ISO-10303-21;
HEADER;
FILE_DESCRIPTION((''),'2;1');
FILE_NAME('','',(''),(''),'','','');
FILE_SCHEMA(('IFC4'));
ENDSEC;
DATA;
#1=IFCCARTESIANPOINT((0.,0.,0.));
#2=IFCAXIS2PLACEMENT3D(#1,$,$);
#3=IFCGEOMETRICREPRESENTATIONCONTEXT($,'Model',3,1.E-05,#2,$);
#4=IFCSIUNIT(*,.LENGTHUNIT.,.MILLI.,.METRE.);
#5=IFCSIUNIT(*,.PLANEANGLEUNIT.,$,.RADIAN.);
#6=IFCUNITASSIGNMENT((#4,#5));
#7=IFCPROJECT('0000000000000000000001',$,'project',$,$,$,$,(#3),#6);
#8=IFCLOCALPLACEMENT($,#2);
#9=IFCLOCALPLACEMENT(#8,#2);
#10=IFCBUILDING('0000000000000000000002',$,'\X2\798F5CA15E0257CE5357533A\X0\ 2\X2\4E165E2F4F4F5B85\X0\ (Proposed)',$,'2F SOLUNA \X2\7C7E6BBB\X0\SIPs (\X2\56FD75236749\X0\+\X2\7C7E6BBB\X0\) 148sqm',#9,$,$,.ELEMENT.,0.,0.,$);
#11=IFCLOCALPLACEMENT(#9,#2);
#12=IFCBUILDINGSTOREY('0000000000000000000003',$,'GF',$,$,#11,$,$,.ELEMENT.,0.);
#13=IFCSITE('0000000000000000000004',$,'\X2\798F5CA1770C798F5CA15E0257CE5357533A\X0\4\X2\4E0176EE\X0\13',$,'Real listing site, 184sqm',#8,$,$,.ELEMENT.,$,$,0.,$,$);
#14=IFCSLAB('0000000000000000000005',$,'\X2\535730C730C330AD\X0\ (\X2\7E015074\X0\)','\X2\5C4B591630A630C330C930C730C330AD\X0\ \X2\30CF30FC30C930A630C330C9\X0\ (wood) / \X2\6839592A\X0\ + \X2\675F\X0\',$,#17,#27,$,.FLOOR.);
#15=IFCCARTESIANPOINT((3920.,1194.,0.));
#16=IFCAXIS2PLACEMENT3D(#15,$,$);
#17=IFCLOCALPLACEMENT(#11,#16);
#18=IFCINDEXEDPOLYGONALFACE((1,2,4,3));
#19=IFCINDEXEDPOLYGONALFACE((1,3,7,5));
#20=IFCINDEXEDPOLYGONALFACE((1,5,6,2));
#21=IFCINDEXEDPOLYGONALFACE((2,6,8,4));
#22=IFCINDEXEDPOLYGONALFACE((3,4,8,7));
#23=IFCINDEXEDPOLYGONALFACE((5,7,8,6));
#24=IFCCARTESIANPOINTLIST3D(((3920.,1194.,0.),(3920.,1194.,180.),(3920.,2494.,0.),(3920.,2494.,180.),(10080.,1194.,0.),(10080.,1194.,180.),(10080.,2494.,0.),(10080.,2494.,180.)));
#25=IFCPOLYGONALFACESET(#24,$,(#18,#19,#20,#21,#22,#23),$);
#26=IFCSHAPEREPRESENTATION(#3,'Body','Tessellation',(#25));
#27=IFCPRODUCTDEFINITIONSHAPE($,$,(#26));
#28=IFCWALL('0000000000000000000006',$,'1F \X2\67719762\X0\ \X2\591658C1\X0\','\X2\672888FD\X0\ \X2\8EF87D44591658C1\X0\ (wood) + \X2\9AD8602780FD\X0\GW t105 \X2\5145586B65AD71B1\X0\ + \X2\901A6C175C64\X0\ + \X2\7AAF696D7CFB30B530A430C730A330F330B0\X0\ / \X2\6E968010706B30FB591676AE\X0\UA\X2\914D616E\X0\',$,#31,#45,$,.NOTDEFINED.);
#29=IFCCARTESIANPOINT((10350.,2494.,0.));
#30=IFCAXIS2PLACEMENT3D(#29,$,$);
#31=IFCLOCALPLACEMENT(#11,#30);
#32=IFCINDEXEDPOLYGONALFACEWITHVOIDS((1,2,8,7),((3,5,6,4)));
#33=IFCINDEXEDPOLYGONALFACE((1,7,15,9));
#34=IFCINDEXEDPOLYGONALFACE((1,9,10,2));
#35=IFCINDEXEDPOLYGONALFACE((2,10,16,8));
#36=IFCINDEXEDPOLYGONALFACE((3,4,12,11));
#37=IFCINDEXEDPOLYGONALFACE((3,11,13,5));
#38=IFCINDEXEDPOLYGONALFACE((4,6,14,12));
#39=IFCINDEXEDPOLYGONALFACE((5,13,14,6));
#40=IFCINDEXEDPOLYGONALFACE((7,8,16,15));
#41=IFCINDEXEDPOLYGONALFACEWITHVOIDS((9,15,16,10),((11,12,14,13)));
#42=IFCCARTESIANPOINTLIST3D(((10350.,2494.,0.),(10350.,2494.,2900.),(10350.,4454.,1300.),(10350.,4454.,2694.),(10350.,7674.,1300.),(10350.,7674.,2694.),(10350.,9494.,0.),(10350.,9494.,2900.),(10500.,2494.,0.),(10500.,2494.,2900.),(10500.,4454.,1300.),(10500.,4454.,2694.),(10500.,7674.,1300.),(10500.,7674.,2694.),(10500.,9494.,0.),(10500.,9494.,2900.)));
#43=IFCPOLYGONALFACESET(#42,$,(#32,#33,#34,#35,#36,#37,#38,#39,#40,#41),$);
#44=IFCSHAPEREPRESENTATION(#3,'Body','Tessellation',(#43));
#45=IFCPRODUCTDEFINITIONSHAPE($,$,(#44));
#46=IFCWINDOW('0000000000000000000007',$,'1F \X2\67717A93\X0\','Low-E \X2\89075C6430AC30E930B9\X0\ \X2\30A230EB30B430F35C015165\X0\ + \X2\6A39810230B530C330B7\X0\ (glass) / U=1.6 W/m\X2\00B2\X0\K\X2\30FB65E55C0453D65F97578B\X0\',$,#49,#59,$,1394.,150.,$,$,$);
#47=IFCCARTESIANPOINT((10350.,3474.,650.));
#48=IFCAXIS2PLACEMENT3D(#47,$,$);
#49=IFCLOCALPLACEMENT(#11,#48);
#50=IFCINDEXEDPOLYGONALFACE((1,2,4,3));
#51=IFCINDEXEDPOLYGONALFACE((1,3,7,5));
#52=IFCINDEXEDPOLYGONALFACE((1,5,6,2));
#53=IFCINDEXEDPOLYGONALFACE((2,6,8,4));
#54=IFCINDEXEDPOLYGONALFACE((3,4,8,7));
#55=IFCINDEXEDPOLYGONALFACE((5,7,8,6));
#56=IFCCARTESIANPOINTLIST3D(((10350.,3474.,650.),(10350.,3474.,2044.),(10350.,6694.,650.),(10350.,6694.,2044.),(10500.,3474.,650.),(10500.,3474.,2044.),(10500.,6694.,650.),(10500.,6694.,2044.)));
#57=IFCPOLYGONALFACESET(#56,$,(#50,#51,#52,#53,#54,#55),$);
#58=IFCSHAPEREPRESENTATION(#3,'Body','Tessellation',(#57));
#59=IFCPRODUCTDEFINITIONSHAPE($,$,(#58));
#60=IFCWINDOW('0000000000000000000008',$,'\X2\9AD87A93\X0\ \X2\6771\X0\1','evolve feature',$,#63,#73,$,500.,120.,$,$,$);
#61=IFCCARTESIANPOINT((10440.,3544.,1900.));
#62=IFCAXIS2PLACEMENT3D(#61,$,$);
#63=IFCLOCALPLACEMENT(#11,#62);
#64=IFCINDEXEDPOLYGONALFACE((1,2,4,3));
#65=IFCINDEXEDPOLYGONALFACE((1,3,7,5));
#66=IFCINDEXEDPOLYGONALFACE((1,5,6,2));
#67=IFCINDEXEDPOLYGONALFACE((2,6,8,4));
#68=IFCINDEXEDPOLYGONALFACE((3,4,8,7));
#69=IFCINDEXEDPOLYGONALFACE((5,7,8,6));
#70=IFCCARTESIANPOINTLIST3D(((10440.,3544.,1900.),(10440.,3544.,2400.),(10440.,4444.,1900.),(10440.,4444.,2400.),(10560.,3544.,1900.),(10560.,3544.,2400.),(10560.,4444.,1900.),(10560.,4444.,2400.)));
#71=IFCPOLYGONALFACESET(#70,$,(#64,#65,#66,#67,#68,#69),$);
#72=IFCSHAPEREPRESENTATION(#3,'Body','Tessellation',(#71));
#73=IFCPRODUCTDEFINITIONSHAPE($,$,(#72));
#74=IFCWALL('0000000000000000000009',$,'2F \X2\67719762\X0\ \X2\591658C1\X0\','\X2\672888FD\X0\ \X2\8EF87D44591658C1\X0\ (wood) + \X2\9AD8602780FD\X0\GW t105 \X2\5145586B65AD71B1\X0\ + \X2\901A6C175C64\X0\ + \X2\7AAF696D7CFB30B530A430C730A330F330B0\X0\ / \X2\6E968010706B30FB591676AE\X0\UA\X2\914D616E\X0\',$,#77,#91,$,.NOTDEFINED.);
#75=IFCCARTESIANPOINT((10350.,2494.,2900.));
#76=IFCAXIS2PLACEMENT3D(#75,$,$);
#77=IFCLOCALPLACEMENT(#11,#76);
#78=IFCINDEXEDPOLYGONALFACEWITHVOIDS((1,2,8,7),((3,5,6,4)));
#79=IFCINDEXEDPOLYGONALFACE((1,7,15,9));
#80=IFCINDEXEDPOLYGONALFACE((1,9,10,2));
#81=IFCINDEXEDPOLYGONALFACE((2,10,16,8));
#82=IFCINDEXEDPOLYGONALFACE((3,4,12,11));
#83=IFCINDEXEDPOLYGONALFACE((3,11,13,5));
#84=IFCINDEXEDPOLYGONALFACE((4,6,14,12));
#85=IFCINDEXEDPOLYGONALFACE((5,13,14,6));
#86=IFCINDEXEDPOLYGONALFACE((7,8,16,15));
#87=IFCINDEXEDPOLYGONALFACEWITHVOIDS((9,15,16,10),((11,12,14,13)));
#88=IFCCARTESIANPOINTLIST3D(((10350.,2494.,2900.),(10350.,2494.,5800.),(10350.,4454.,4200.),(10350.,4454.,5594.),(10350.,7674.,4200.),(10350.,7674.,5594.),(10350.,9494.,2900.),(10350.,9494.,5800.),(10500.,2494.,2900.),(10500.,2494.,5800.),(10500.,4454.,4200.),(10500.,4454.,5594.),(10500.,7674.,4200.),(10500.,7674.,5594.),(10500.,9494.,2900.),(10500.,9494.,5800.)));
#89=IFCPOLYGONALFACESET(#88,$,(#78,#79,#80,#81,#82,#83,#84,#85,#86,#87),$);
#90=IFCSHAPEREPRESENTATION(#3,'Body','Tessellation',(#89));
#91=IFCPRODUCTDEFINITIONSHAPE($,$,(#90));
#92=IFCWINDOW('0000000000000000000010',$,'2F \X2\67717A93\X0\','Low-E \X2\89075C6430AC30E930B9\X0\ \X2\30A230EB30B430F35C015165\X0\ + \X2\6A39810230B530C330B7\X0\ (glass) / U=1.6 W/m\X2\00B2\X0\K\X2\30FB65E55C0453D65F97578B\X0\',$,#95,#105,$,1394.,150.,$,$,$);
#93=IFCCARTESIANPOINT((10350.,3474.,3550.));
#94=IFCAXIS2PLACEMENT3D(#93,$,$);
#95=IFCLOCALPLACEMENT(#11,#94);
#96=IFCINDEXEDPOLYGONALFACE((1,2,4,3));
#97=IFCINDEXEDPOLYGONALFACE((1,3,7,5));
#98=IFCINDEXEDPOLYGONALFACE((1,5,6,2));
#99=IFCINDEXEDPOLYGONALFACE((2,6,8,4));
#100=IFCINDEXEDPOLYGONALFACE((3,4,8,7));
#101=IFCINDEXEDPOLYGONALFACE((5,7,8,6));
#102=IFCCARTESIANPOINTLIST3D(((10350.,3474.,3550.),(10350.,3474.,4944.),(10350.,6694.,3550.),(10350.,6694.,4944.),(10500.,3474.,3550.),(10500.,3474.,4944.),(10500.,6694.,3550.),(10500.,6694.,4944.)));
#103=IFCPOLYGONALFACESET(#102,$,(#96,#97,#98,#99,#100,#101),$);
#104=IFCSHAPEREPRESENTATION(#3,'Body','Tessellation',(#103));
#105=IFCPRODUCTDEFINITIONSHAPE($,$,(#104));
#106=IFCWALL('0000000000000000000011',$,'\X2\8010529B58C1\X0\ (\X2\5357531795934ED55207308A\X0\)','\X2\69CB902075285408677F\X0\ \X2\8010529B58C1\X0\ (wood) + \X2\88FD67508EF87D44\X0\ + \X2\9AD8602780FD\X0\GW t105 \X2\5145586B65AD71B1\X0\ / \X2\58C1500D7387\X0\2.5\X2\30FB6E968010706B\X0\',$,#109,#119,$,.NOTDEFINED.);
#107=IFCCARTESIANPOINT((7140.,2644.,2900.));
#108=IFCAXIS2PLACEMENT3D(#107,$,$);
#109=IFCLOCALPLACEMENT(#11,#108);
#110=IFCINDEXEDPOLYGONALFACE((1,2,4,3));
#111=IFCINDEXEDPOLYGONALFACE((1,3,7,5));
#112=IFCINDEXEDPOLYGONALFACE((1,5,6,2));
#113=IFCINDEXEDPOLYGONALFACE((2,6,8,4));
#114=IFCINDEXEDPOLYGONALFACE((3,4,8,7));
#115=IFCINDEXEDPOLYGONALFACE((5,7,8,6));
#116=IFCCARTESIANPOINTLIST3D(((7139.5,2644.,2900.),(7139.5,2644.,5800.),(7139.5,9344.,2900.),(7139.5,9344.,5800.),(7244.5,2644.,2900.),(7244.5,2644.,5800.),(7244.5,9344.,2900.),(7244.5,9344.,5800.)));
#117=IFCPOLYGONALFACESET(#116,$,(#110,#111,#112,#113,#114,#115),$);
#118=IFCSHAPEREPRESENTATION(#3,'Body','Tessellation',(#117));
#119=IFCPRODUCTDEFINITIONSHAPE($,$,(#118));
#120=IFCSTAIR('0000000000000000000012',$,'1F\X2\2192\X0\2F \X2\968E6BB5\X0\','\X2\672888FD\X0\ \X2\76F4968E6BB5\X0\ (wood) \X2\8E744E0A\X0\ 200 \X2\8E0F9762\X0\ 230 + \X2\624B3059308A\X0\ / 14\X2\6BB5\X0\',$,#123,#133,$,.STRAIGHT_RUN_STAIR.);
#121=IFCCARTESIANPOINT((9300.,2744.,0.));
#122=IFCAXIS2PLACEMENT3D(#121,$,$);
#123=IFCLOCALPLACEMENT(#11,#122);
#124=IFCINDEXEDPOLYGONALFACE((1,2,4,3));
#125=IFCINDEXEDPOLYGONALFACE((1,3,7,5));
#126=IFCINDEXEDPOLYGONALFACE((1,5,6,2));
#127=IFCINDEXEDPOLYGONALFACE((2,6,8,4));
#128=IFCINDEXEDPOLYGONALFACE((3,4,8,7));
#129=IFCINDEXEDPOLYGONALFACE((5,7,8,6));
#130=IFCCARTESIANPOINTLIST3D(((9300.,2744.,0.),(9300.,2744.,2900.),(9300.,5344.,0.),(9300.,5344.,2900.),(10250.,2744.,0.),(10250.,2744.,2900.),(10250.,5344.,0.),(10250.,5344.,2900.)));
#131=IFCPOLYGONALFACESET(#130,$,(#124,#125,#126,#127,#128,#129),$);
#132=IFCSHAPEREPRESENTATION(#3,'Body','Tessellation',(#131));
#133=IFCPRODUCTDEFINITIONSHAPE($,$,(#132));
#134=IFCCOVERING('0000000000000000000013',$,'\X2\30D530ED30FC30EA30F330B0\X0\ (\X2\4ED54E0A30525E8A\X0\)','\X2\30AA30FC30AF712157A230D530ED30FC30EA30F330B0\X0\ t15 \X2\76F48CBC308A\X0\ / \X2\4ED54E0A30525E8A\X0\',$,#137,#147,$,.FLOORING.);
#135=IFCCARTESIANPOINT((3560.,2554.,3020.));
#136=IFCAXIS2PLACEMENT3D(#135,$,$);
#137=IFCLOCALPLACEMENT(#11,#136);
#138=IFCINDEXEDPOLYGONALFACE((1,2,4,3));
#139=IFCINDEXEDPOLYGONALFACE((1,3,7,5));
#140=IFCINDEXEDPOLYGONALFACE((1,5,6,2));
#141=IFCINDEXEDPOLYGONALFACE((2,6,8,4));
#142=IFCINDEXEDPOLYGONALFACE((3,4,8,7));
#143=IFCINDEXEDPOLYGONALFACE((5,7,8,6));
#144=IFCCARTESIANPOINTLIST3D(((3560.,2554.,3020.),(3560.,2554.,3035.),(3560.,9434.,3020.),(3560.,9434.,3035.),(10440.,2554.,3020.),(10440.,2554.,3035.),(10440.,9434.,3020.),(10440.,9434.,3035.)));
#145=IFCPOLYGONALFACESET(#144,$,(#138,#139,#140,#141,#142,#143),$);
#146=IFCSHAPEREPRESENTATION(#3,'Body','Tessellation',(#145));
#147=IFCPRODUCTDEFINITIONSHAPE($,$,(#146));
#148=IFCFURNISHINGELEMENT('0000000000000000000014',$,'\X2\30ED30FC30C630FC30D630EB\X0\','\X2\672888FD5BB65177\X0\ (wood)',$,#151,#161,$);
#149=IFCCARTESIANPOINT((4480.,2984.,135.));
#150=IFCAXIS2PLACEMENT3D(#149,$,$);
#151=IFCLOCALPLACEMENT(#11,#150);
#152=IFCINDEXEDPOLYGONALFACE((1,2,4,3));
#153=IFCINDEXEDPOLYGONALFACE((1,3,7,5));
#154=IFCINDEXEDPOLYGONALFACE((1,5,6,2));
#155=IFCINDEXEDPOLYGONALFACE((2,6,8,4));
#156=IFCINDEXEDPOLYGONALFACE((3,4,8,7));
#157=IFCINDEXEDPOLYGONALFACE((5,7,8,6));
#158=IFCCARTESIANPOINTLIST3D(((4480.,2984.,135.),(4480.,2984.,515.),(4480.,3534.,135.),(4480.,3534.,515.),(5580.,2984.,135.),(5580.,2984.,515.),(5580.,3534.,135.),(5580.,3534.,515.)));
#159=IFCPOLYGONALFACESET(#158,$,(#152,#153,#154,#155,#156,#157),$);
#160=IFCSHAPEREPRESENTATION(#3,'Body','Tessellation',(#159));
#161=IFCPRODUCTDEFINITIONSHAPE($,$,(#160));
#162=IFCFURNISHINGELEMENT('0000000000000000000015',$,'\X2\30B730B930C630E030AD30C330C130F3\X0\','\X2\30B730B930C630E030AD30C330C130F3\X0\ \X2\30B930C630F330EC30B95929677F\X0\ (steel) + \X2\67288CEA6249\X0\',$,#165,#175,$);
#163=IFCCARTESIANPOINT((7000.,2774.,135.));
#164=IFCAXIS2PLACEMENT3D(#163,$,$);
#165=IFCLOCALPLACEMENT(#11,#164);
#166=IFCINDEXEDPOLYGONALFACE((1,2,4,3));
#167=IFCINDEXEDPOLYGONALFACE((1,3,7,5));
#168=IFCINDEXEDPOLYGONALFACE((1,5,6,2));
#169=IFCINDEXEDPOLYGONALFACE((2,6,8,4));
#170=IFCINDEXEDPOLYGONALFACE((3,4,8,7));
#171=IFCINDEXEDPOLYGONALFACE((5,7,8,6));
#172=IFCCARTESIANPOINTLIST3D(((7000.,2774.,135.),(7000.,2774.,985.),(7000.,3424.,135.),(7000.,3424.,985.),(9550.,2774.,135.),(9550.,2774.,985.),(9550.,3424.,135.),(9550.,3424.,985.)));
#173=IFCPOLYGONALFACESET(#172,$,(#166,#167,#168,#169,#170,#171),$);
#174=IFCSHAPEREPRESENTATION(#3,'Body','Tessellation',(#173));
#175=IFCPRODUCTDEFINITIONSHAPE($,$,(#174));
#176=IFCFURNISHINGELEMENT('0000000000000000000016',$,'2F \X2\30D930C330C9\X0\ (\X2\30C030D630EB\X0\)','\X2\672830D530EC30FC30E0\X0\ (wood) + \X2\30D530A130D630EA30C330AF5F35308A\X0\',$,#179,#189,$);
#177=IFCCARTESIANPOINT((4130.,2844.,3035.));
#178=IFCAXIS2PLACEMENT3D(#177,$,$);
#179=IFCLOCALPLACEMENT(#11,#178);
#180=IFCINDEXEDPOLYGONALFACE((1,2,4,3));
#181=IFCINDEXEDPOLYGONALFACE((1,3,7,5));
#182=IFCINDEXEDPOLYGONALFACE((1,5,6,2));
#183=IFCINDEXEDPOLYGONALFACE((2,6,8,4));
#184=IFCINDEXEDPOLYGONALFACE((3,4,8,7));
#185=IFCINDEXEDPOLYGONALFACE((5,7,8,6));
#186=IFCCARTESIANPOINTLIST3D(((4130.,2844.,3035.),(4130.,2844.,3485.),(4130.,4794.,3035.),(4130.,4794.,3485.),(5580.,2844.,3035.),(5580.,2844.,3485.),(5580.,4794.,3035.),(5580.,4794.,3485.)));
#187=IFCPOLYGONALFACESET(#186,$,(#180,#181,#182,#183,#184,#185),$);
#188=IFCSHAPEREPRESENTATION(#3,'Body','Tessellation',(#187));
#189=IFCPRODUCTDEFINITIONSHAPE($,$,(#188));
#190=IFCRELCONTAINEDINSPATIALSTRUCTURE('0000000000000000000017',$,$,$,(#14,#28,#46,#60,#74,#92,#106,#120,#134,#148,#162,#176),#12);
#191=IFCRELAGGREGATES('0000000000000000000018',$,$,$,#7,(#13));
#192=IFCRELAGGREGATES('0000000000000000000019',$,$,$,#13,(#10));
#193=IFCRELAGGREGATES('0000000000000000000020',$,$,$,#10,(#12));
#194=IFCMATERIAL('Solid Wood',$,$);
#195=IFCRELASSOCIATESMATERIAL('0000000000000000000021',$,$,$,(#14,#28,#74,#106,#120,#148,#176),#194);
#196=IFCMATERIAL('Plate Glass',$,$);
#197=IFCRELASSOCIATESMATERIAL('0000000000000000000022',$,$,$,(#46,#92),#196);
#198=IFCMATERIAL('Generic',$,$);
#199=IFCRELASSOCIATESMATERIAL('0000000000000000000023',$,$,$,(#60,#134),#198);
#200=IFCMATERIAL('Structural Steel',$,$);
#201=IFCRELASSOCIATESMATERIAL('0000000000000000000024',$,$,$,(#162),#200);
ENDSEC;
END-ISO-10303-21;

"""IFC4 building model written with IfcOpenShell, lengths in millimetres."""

from ifc_helpers import new_model, si_unit, frame, frame_2d, origin, place, context, project, spatial, rectangle, extrude, material, element, fill, save


model = new_model("IFC4")

# Units and contexts
model_context = context("Model", 3, precision=1e-05, world=origin())
ifc_project = project(units=[si_unit("LENGTHUNIT", "METRE", prefix="MILLI"), si_unit("PLANEANGLEUNIT", "RADIAN")], contexts=[model_context])

# Site, building, storey
site_placement = place(None, origin())
site = spatial("IfcSite", under=ifc_project, at=site_placement, Name="福岡県福岡市城南区4丁目13", ObjectType="Real listing site, 184sqm", CompositionType="ELEMENT", RefElevation=0.0)
building_placement = place(site_placement, origin())
building = spatial("IfcBuilding", under=site, at=building_placement, Name="福岡市城南区 2世帯住宅 (Proposed)", ObjectType="2F SOLUNA 籾殻SIPs (国産杉+籾殻) 148sqm", CompositionType="ELEMENT", ElevationOfRefHeight=0.0, ElevationOfTerrain=0.0)
storey_placement = place(building_placement, origin())
storey = spatial("IfcBuildingStorey", under=building, at=storey_placement, Name="GF", CompositionType="ELEMENT", Elevation=0.0)

# Slab
ifc_material_1 = material(Name="Solid Wood")
slab_placement = place(storey_placement, frame((3920.0, 1194.0, 0.0)))
element("IfcSlab", 1, at=slab_placement, inside=storey, material=ifc_material_1, Name="南デッキ (縁側)", Description="屋外ウッドデッキ ハードウッド (wood) / 根太 + 束", PredefinedType="FLOOR", context=model_context, shape_type="SweptSolid", body=[
    extrude(rectangle(XDim=6160.0, YDim=1300.0, at=frame_2d((3080.0, 650.0))), frame((3920.0, 1194.0, 0.0)), (0.0, 0.0, 1.0), 180.0),
])

# Wall, openings, windows
wall_1_placement = place(storey_placement, frame((10350.0, 2494.0, 0.0)))
wall_1 = element("IfcWall", 2, at=wall_1_placement, inside=storey, material=ifc_material_1, Name="1F 東面 外壁", Description="木製 軸組外壁 (wood) + 高性能GW t105 充填断熱 + 通気層 + 窯業系サイディング / 準耐火・外皮UA配慮", PredefinedType="NOTDEFINED", context=model_context, shape_type="SweptSolid", body=[
    extrude(rectangle(XDim=150.0, YDim=7000.0, at=frame_2d((75.0, 3500.0))), frame((10350.0, 2494.0, 0.0)), (0.0, 0.0, 1.0), 2900.0),
])
opening_1_placement = place(storey_placement, frame((10350.0, 3474.0, 650.0)))
opening_1 = element("IfcOpeningElement", 3, at=opening_1_placement, cuts=wall_1, PredefinedType="NOTDEFINED", context=model_context, shape_type="SweptSolid", body=[
    extrude(rectangle(XDim=150.0, YDim=3220.0, at=frame_2d((75.0, 1610.0))), frame((10350.0, 3474.0, 650.0)), (0.0, 0.0, 1.0), 1394.0),
])
opening_2_placement = place(storey_placement, frame((10440.0, 3544.0, 1900.0)))
opening_2 = element("IfcOpeningElement", 4, at=opening_2_placement, cuts=wall_1, PredefinedType="NOTDEFINED", context=model_context, shape_type="SweptSolid", body=[
    extrude(rectangle(XDim=120.0, YDim=900.0, at=frame_2d((60.0, 450.0))), frame((10440.0, 3544.0, 1900.0)), (0.0, 0.0, 1.0), 500.0),
])
ifc_material_2 = material(Name="Plate Glass")
window_1_placement = place(storey_placement, frame((10350.0, 3474.0, 650.0)))
window_1 = element("IfcWindow", 5, at=window_1_placement, inside=storey, material=ifc_material_2, Name="1F 東窓", Description="Low-E 複層ガラス アルゴン封入 + 樹脂サッシ (glass) / U=1.6 W/m²K・日射取得型", OverallHeight=1394.0, OverallWidth=150.0, context=model_context, shape_type="SweptSolid", body=[
    extrude(rectangle(XDim=150.0, YDim=3220.0, at=frame_2d((75.0, 1610.0))), frame((10350.0, 3474.0, 650.0)), (0.0, 0.0, 1.0), 1394.0),
])
fill(opening_1, window_1)
ifc_material_3 = material(Name="Generic")
window_2_placement = place(storey_placement, frame((10440.0, 3544.0, 1900.0)))
window_2 = element("IfcWindow", 6, at=window_2_placement, inside=storey, material=ifc_material_3, Name="高窓 東1", Description="evolve feature", OverallHeight=500.0, OverallWidth=120.0, context=model_context, shape_type="SweptSolid", body=[
    extrude(rectangle(XDim=120.0, YDim=900.0, at=frame_2d((60.0, 450.0))), frame((10440.0, 3544.0, 1900.0)), (0.0, 0.0, 1.0), 500.0),
])
fill(opening_2, window_2)

# Wall, opening, window
wall_2_placement = place(storey_placement, frame((10350.0, 2494.0, 2900.0)))
wall_2 = element("IfcWall", 7, at=wall_2_placement, inside=storey, material=ifc_material_1, Name="2F 東面 外壁", Description="木製 軸組外壁 (wood) + 高性能GW t105 充填断熱 + 通気層 + 窯業系サイディング / 準耐火・外皮UA配慮", PredefinedType="NOTDEFINED", context=model_context, shape_type="SweptSolid", body=[
    extrude(rectangle(XDim=150.0, YDim=7000.0, at=frame_2d((75.0, 3500.0))), frame((10350.0, 2494.0, 2900.0)), (0.0, 0.0, 1.0), 2900.0),
])
opening_3_placement = place(storey_placement, frame((10350.0, 3474.0, 3550.0)))
opening_3 = element("IfcOpeningElement", 8, at=opening_3_placement, cuts=wall_2, PredefinedType="NOTDEFINED", context=model_context, shape_type="SweptSolid", body=[
    extrude(rectangle(XDim=150.0, YDim=3220.0, at=frame_2d((75.0, 1610.0))), frame((10350.0, 3474.0, 3550.0)), (0.0, 0.0, 1.0), 1394.0),
])
window_3_placement = place(storey_placement, frame((10350.0, 3474.0, 3550.0)))
window_3 = element("IfcWindow", 9, at=window_3_placement, inside=storey, material=ifc_material_2, Name="2F 東窓", Description="Low-E 複層ガラス アルゴン封入 + 樹脂サッシ (glass) / U=1.6 W/m²K・日射取得型", OverallHeight=1394.0, OverallWidth=150.0, context=model_context, shape_type="SweptSolid", body=[
    extrude(rectangle(XDim=150.0, YDim=3220.0, at=frame_2d((75.0, 1610.0))), frame((10350.0, 3474.0, 3550.0)), (0.0, 0.0, 1.0), 1394.0),
])
fill(opening_3, window_3)

# Wall
wall_3_placement = place(storey_placement, frame((7140.0, 2644.0, 2900.0)))
element("IfcWall", 10, at=wall_3_placement, inside=storey, material=ifc_material_1, Name="耐力壁 (南北間仕切り)", Description="構造用合板 耐力壁 (wood) + 製材軸組 + 高性能GW t105 充填断熱 / 壁倍率2.5・準耐火", PredefinedType="NOTDEFINED", context=model_context, shape_type="SweptSolid", body=[
    extrude(rectangle(XDim=105.0, YDim=6700.0, at=frame_2d((52.0, 3350.0))), frame((7140.0, 2644.0, 2900.0)), (0.0, 0.0, 1.0), 2900.0),
])

# Stair
stair_placement = place(storey_placement, frame((9300.0, 2744.0, 0.0)))
element("IfcStair", 11, at=stair_placement, inside=storey, material=ifc_material_1, Name="1F→2F 階段", Description="木製 直階段 (wood) 蹴上 200 踏面 230 + 手すり / 14段", PredefinedType="STRAIGHT_RUN_STAIR", context=model_context, shape_type="SweptSolid", body=[
    extrude(rectangle(XDim=950.0, YDim=2600.0, at=frame_2d((475.0, 1300.0))), frame((9300.0, 2744.0, 0.0)), (0.0, 0.0, 1.0), 2900.0),
])

# Covering
covering_placement = place(storey_placement, frame((3560.0, 2554.0, 3020.0)))
element("IfcCovering", 12, at=covering_placement, inside=storey, material=ifc_material_3, Name="フローリング (仕上げ床)", Description="オーク無垢フローリング t15 直貼り / 仕上げ床", PredefinedType="FLOORING", context=model_context, shape_type="SweptSolid", body=[
    extrude(rectangle(XDim=6880.0, YDim=6880.0, at=frame_2d((3440.0, 3440.0))), frame((3560.0, 2554.0, 3020.0)), (0.0, 0.0, 1.0), 15.0),
])

# Furnishing elements
furnishing_1_placement = place(storey_placement, frame((4480.0, 2984.0, 135.0)))
element("IfcFurnishingElement", 13, at=furnishing_1_placement, inside=storey, material=ifc_material_1, Name="ローテーブル", Description="木製家具 (wood)", context=model_context, shape_type="SweptSolid", body=[
    extrude(rectangle(XDim=1100.0, YDim=550.0, at=frame_2d((550.0, 275.0))), frame((4480.0, 2984.0, 135.0)), (0.0, 0.0, 1.0), 380.0),
])
ifc_material_4 = material(Name="Structural Steel")
furnishing_2_placement = place(storey_placement, frame((7000.0, 2774.0, 135.0)))
element("IfcFurnishingElement", 14, at=furnishing_2_placement, inside=storey, material=ifc_material_4, Name="システムキッチン", Description="システムキッチン ステンレス天板 (steel) + 木質扉", context=model_context, shape_type="SweptSolid", body=[
    extrude(rectangle(XDim=2550.0, YDim=650.0, at=frame_2d((1275.0, 325.0))), frame((7000.0, 2774.0, 135.0)), (0.0, 0.0, 1.0), 850.0),
])
furnishing_3_placement = place(storey_placement, frame((4130.0, 2844.0, 3035.0)))
element("IfcFurnishingElement", 15, at=furnishing_3_placement, inside=storey, material=ifc_material_1, Name="2F ベッド (ダブル)", Description="木フレーム (wood) + ファブリック張り", context=model_context, shape_type="SweptSolid", body=[
    extrude(rectangle(XDim=1450.0, YDim=1950.0, at=frame_2d((725.0, 975.0))), frame((4130.0, 2844.0, 3035.0)), (0.0, 0.0, 1.0), 450.0),
])

save(model, "model.ifc")
